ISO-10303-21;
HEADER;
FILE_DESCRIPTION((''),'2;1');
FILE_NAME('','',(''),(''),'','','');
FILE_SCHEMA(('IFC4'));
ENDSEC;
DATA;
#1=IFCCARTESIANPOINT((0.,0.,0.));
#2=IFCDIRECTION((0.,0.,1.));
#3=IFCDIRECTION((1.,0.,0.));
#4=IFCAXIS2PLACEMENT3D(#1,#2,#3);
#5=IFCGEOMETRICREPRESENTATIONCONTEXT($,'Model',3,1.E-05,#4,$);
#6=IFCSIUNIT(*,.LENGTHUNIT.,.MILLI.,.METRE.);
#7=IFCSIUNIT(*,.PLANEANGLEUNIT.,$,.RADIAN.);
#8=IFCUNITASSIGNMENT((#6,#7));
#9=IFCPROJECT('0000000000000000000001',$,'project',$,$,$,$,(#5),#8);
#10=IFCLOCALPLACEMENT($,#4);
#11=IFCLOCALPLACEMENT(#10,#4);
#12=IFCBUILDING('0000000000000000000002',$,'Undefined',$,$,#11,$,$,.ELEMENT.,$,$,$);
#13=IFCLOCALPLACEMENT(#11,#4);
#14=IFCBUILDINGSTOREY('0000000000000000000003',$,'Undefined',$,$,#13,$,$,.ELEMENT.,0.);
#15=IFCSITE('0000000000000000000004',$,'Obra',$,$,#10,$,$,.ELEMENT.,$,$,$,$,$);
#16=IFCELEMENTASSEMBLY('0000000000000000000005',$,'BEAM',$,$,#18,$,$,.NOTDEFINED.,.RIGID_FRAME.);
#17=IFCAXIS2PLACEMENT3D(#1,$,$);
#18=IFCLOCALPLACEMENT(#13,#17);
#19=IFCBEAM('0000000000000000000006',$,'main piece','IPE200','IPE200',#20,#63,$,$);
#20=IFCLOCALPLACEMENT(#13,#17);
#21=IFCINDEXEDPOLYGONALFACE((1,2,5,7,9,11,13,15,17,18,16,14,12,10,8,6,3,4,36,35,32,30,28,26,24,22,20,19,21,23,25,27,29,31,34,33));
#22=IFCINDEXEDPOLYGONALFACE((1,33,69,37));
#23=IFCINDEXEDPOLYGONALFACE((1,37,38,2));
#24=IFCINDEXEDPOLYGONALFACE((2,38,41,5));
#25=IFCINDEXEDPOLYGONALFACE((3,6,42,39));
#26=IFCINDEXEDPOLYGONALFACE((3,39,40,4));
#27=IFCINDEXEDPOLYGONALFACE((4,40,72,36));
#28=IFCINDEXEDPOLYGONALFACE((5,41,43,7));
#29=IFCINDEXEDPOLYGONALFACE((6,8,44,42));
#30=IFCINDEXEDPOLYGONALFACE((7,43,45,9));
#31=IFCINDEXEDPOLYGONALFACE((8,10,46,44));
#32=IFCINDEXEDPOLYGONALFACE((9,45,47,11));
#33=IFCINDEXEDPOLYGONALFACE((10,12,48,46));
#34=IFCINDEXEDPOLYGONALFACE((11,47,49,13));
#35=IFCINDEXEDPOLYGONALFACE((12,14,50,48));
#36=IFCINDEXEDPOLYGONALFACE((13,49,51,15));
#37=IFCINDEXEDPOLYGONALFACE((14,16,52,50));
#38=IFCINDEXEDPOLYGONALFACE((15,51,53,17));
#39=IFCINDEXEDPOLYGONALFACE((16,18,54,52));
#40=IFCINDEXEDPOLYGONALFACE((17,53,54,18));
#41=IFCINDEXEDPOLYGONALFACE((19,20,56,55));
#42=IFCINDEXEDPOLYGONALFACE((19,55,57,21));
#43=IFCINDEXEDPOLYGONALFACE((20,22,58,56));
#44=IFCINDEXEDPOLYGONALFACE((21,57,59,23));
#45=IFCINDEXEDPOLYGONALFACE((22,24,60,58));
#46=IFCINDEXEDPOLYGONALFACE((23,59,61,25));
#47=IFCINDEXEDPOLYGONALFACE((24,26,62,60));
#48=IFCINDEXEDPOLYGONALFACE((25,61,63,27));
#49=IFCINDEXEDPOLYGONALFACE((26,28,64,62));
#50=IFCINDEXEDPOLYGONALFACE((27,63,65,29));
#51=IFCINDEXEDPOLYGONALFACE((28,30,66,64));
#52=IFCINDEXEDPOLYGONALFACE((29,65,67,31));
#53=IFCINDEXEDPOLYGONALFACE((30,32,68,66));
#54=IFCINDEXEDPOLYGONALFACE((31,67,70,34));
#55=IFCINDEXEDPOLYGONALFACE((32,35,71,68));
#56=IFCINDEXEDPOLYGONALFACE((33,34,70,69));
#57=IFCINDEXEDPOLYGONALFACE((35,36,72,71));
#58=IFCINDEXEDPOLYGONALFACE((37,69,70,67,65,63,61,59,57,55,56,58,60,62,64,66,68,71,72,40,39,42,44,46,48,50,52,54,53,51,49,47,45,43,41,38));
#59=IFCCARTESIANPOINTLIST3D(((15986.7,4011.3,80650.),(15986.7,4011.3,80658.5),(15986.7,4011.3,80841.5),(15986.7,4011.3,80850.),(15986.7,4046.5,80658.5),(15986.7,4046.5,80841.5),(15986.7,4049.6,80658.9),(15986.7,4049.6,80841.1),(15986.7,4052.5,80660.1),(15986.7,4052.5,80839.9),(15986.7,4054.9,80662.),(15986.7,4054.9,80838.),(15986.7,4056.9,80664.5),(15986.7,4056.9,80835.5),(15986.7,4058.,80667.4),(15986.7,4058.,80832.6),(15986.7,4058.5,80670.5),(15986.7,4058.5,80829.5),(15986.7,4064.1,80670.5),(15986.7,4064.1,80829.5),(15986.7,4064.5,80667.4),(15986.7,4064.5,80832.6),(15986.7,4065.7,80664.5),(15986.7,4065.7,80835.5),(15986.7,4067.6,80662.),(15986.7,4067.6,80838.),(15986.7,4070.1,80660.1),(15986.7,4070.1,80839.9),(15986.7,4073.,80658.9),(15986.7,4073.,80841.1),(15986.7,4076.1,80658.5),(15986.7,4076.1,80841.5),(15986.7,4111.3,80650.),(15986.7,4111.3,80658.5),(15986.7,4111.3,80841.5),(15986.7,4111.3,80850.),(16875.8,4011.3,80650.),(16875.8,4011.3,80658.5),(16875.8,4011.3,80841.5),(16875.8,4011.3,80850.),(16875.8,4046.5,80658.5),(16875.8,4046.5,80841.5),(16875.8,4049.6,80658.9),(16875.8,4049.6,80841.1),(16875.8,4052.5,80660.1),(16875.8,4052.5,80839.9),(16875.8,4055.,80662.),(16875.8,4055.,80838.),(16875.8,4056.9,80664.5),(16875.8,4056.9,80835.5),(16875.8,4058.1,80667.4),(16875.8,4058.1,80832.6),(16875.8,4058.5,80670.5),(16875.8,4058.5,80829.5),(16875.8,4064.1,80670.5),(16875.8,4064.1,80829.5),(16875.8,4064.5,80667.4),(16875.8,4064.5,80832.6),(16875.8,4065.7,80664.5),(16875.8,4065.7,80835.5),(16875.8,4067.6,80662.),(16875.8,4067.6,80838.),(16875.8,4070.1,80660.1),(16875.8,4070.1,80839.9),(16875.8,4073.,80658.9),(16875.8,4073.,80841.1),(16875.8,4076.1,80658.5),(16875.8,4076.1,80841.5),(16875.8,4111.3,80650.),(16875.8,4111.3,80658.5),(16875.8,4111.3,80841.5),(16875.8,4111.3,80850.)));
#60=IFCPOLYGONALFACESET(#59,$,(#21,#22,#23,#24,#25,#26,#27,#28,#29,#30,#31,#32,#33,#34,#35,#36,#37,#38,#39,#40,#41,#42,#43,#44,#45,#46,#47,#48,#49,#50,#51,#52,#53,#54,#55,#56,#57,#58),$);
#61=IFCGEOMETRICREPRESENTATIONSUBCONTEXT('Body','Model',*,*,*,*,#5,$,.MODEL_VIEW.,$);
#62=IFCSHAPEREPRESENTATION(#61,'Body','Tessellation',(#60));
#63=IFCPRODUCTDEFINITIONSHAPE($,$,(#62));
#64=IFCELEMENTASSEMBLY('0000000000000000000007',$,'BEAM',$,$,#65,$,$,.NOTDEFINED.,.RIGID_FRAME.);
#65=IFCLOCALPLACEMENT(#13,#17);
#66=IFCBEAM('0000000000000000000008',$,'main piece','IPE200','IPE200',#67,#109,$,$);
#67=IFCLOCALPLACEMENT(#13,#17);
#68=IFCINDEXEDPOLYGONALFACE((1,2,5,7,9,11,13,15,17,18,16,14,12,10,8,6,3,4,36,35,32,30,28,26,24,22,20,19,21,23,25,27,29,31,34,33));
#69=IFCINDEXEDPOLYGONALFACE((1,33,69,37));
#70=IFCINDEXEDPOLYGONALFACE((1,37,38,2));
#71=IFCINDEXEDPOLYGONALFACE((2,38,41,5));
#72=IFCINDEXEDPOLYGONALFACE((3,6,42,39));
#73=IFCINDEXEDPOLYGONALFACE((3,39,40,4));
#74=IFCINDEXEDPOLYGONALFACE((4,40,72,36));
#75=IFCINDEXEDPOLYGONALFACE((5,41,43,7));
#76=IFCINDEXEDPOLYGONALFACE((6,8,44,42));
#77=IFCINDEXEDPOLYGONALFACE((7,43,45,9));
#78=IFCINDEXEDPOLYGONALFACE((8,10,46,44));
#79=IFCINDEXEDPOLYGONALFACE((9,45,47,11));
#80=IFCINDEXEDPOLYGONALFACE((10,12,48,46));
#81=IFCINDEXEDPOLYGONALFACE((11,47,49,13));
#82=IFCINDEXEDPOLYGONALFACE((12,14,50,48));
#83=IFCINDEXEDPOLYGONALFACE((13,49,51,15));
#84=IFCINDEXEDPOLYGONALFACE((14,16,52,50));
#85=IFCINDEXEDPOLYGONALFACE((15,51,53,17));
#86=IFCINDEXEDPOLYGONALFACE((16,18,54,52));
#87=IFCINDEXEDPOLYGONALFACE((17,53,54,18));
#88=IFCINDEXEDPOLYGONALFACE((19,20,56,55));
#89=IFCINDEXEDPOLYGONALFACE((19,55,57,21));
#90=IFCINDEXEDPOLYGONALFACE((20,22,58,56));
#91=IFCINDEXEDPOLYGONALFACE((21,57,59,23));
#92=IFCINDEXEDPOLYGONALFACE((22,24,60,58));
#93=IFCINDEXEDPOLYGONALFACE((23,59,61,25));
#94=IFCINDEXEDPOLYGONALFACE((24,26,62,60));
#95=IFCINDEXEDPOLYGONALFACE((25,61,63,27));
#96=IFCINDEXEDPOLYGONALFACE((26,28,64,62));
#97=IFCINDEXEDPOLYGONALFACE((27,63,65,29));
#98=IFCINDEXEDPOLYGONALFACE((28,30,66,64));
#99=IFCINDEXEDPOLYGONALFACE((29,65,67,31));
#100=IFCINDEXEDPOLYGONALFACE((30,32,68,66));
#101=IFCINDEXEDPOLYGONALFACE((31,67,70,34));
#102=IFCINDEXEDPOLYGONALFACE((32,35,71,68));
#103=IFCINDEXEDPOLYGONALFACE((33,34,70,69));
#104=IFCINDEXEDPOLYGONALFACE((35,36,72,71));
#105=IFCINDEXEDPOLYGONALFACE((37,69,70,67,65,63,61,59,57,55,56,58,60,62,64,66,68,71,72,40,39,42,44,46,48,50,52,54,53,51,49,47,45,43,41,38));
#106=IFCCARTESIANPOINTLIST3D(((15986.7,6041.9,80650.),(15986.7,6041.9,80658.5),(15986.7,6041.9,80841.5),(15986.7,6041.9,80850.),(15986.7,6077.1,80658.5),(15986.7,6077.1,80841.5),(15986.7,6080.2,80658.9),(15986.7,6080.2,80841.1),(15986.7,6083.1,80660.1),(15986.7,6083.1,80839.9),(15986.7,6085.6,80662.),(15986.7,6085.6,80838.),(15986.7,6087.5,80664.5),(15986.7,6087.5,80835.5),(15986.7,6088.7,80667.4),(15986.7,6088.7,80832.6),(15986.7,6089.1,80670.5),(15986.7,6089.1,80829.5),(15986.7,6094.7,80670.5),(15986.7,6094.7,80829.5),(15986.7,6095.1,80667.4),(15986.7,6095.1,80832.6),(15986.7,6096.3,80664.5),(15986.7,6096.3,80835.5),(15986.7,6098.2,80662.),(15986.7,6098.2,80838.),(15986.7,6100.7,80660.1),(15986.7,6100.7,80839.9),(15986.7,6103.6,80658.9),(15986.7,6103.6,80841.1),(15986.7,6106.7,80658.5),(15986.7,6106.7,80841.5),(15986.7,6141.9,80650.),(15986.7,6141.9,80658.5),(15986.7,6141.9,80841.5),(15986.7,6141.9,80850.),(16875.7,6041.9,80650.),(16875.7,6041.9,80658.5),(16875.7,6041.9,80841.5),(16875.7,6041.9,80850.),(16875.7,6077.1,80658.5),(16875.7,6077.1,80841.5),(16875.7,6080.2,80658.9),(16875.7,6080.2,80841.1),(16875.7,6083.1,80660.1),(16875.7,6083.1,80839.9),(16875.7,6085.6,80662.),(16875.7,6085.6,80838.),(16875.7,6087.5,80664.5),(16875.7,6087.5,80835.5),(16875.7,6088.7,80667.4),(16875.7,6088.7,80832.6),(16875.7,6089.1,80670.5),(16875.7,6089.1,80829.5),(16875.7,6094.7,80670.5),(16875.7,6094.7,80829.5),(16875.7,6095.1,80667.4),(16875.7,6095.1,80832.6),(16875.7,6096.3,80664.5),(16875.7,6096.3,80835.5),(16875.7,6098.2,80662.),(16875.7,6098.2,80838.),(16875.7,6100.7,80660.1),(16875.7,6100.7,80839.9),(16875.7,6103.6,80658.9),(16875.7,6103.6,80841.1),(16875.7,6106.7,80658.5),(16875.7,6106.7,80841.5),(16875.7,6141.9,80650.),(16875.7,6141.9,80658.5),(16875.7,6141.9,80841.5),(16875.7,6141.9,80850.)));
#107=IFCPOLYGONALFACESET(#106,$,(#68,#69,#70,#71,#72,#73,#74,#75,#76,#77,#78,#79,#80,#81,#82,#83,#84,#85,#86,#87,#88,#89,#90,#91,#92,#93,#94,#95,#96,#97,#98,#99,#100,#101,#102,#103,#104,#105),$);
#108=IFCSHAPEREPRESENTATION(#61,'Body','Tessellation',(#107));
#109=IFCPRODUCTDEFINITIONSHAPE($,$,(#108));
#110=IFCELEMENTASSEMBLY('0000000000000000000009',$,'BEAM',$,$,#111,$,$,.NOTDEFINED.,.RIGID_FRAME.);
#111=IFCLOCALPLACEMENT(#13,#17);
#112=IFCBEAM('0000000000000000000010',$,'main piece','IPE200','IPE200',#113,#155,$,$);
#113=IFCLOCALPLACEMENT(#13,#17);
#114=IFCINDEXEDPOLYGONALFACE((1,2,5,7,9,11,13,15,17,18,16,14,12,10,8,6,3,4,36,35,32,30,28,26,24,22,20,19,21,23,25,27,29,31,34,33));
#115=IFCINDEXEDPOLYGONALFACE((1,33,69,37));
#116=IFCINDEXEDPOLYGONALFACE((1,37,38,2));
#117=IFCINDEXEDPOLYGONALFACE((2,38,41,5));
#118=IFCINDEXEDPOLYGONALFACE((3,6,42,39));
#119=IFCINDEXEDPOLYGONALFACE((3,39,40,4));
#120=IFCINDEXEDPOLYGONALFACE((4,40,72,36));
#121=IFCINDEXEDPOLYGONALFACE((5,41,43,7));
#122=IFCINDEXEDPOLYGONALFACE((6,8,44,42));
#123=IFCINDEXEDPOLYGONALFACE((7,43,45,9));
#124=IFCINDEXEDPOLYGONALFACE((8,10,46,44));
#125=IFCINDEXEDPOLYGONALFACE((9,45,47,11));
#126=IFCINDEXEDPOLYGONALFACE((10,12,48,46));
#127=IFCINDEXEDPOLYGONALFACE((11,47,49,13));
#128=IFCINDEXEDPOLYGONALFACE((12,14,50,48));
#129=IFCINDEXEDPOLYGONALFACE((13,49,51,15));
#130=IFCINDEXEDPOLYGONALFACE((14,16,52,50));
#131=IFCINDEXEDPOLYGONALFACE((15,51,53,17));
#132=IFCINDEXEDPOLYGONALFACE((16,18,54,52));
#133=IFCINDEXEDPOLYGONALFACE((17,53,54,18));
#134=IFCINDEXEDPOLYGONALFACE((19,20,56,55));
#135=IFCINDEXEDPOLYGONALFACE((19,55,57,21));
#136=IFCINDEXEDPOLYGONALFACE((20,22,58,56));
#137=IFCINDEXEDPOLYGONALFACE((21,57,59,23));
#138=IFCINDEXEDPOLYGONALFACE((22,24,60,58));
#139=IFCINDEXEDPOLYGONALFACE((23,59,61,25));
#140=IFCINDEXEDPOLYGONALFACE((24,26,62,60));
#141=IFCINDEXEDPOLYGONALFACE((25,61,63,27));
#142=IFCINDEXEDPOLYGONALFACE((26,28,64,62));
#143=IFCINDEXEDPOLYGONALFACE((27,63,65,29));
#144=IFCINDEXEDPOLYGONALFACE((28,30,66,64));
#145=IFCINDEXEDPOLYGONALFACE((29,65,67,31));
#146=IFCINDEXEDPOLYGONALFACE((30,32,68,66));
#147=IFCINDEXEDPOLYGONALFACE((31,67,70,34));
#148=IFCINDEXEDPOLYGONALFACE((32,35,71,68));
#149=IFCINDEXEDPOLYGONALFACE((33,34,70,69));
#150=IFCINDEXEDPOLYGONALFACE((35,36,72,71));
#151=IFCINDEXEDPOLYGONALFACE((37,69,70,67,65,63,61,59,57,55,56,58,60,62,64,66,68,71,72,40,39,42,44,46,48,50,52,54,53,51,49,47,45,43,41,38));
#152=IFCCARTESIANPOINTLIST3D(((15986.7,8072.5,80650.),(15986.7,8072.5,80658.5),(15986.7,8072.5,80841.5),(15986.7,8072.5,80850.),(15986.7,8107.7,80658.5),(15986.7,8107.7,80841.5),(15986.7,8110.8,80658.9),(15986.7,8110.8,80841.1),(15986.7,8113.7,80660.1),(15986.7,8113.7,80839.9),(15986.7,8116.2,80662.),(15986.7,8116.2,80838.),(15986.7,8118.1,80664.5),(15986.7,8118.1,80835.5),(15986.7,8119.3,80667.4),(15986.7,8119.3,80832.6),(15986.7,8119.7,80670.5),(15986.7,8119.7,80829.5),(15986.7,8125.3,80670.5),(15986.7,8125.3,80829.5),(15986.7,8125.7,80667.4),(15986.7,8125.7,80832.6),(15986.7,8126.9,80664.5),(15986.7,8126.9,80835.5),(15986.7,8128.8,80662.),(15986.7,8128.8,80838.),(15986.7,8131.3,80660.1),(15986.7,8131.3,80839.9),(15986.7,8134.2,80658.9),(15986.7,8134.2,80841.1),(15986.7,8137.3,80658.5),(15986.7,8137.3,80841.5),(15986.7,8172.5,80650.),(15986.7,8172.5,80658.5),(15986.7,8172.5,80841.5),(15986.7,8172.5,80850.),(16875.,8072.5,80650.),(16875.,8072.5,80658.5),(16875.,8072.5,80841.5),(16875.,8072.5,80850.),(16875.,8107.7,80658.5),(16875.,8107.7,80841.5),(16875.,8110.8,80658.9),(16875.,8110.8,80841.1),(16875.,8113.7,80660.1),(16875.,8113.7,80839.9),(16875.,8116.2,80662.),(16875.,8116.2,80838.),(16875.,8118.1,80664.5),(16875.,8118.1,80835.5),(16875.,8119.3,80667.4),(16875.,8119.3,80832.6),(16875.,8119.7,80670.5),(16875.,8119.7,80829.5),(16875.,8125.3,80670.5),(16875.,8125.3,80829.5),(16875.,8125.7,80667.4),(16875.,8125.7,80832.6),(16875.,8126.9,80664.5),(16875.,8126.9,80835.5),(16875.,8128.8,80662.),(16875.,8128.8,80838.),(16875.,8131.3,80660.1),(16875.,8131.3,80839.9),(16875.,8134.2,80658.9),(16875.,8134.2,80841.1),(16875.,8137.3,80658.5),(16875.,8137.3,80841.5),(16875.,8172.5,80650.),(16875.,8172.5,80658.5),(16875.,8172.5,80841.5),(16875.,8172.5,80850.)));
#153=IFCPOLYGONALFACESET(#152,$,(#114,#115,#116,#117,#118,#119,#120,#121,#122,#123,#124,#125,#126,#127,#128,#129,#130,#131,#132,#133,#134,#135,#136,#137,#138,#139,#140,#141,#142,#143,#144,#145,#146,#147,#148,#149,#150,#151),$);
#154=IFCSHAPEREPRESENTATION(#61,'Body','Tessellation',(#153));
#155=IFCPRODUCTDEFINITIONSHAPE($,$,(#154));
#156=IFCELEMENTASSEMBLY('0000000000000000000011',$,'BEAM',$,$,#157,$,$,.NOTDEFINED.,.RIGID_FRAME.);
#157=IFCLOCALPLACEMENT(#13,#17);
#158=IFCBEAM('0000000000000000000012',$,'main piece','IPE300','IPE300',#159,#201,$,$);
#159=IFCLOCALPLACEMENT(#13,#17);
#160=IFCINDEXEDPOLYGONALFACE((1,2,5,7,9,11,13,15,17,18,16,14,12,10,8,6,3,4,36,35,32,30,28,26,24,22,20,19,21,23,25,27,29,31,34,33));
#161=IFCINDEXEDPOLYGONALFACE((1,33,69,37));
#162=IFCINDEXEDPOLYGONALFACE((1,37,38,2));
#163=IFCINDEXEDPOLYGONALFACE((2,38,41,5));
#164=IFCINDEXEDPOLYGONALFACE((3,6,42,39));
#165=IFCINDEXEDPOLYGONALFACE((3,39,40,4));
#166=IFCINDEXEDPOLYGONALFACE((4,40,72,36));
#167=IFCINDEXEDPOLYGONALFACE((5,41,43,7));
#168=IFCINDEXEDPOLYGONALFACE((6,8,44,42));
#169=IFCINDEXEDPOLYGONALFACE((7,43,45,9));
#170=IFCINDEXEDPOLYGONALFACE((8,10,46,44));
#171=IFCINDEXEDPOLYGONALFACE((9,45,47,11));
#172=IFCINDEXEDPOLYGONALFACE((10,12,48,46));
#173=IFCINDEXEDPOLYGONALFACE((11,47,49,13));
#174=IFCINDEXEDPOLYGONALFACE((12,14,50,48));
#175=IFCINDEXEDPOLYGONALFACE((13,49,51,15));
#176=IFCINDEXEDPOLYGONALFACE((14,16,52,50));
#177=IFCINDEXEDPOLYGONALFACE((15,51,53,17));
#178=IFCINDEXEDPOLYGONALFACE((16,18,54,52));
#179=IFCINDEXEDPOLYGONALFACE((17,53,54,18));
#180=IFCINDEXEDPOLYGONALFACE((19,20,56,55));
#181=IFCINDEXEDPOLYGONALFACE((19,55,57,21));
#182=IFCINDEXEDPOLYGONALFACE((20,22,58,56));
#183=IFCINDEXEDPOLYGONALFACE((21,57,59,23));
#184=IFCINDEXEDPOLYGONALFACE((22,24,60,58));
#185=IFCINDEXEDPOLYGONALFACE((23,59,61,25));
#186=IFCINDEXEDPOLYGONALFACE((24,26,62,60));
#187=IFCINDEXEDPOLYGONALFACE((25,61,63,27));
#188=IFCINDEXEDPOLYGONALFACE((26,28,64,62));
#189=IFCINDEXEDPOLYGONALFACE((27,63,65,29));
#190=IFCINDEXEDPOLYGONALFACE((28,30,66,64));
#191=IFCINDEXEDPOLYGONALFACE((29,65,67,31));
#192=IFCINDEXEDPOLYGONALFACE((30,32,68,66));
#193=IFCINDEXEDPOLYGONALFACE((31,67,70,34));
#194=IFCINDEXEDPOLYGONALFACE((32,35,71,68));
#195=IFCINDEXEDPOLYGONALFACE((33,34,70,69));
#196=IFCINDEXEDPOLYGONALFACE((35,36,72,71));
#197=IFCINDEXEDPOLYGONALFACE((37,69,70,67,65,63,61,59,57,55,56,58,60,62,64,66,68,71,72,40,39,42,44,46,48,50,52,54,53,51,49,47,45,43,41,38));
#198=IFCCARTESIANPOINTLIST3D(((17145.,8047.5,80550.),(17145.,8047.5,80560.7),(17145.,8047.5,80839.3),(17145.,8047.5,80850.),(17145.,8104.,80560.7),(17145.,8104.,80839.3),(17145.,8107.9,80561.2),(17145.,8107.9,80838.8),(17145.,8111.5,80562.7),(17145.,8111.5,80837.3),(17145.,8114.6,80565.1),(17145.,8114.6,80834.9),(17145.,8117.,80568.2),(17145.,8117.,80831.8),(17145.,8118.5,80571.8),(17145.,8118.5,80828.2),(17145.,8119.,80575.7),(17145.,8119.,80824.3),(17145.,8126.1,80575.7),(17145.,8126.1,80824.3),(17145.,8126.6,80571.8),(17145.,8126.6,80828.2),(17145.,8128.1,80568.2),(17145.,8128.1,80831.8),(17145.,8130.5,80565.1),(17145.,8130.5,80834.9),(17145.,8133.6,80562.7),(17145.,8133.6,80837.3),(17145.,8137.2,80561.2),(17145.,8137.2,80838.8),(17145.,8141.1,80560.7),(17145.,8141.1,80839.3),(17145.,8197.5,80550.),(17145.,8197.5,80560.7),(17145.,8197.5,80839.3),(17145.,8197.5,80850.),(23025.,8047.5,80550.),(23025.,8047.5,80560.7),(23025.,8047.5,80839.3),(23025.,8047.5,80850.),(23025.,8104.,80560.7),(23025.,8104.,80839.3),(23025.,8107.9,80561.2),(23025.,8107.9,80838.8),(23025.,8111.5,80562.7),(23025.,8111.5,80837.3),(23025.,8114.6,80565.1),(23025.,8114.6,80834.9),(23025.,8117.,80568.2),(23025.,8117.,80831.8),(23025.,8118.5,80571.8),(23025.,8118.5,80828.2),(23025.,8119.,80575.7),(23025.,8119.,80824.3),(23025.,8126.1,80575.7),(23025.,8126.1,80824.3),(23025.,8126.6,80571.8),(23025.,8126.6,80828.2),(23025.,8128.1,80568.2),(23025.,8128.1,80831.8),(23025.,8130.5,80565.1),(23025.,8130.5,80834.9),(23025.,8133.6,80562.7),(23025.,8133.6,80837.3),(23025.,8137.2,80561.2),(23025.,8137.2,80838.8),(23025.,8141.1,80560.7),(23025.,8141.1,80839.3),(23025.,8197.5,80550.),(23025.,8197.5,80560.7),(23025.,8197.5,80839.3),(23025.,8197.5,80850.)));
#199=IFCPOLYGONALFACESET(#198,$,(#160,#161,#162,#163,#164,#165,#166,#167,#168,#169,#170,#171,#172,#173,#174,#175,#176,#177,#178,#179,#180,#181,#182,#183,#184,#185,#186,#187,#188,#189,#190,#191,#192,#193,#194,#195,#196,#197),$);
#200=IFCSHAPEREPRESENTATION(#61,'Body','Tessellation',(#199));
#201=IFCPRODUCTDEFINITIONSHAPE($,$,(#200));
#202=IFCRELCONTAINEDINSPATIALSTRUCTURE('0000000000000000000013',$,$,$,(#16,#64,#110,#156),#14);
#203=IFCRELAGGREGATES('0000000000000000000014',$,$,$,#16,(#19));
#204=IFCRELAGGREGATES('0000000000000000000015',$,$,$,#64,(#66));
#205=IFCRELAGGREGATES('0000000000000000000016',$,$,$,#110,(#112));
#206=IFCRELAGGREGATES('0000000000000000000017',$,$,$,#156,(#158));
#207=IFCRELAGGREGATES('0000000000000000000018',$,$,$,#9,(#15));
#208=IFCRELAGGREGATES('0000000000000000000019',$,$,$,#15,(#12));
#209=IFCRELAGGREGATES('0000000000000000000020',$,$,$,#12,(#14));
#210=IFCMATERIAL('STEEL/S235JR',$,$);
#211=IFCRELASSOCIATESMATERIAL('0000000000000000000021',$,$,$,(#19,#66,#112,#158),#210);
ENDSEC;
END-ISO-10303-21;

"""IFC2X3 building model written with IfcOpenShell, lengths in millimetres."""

from ifc_helpers import new_model, si_unit, frame, origin_with_axes, origin_2d_with_axis, place, context, subcontext, project, spatial, i_section, extrude, material, element, aggregate, save


model = new_model("IFC2X3")

# Units and contexts
model_context = context("Model", 3, precision=1e-05, world=origin_with_axes())
body_context = subcontext(model_context, "Body", "Model", "MODEL_VIEW")
ifc_project = project(units=[si_unit("LENGTHUNIT", "METRE", prefix="MILLI"), si_unit("PLANEANGLEUNIT", "RADIAN")], contexts=[model_context])

# Site, building, storey
site_placement = place(None, origin_with_axes())
site = spatial("IfcSite", under=ifc_project, at=site_placement, Name="Obra", CompositionType="ELEMENT")
building_placement = place(site_placement, origin_with_axes())
building = spatial("IfcBuilding", under=site, at=building_placement, Name="Undefined", CompositionType="ELEMENT")
storey_placement = place(building_placement, origin_with_axes())
storey = spatial("IfcBuildingStorey", under=building, at=storey_placement, Name="Undefined", CompositionType="ELEMENT", Elevation=0.0)

# Element assemblies, beams
ifc_material = material(Name="STEEL/S235JR")
assembly_1_placement = place(storey_placement, origin_with_axes())
assembly_1 = element("IfcElementAssembly", 1, at=assembly_1_placement, inside=storey, Name="BEAM", AssemblyPlace="NOTDEFINED", PredefinedType="RIGID_FRAME")
beam_1_placement = place(assembly_1_placement, frame((16875.8, 4061.3, 80750.0), z_axis=(0.0, 0.0, 1.0), x_axis=(-1.0, -0.000044, 0.0)))
beam_1 = element("IfcBeam", 2, at=beam_1_placement, material=ifc_material, Name="main piece", Description="IPE200", ObjectType="IPE200", context=body_context, shape_type="SweptSolid", body=[
    extrude(i_section(OverallWidth=100.0, OverallDepth=200.0, WebThickness=5.6, FlangeThickness=8.5, FilletRadius=12.0, at=origin_2d_with_axis()), frame((889.1, 0.0, 0.0), z_axis=(-1.0, 0.0, 0.0), x_axis=(0.0, -1.0, 0.0)), (0.0, 0.0, 1.0), 889.1),
])
aggregate(assembly_1, [beam_1])
assembly_2_placement = place(storey_placement, origin_with_axes())
assembly_2 = element("IfcElementAssembly", 3, at=assembly_2_placement, inside=storey, Name="BEAM", AssemblyPlace="NOTDEFINED", PredefinedType="RIGID_FRAME")
beam_2_placement = place(assembly_2_placement, frame((16875.7, 6091.9, 80750.0), z_axis=(0.0, 0.0, 1.0), x_axis=(-1.0, 0.0, 0.0)))
beam_2 = element("IfcBeam", 4, at=beam_2_placement, material=ifc_material, Name="main piece", Description="IPE200", ObjectType="IPE200", context=body_context, shape_type="SweptSolid", body=[
    extrude(i_section(OverallWidth=100.0, OverallDepth=200.0, WebThickness=5.6, FlangeThickness=8.5, FilletRadius=12.0, at=origin_2d_with_axis()), frame((889.0, 0.0, 0.0), z_axis=(-1.0, 0.0, 0.0), x_axis=(0.0, -1.0, 0.0)), (0.0, 0.0, 1.0), 889.0),
])
aggregate(assembly_2, [beam_2])
assembly_3_placement = place(storey_placement, origin_with_axes())
assembly_3 = element("IfcElementAssembly", 5, at=assembly_3_placement, inside=storey, Name="BEAM", AssemblyPlace="NOTDEFINED", PredefinedType="RIGID_FRAME")
beam_3_placement = place(assembly_3_placement, frame((15986.7, 8122.5, 80750.0), z_axis=(0.0, 0.0, 1.0), x_axis=(1.0, 0.0, 0.0)))
beam_3 = element("IfcBeam", 6, at=beam_3_placement, material=ifc_material, Name="main piece", Description="IPE200", ObjectType="IPE200", context=body_context, shape_type="SweptSolid", body=[
    extrude(i_section(OverallWidth=100.0, OverallDepth=200.0, WebThickness=5.6, FlangeThickness=8.5, FilletRadius=12.0, at=origin_2d_with_axis()), frame((888.3, 0.0, 0.0), z_axis=(-1.0, 0.0, 0.0), x_axis=(0.0, -1.0, 0.0)), (0.0, 0.0, 1.0), 888.3),
])
aggregate(assembly_3, [beam_3])
assembly_4_placement = place(storey_placement, origin_with_axes())
assembly_4 = element("IfcElementAssembly", 7, at=assembly_4_placement, inside=storey, Name="BEAM", AssemblyPlace="NOTDEFINED", PredefinedType="RIGID_FRAME")
beam_4_placement = place(assembly_4_placement, frame((17145.0, 8122.5, 80700.0), z_axis=(0.0, 0.0, 1.0), x_axis=(1.0, 0.0, 0.0)))
beam_4 = element("IfcBeam", 8, at=beam_4_placement, material=ifc_material, Name="main piece", Description="IPE300", ObjectType="IPE300", context=body_context, shape_type="SweptSolid", body=[
    extrude(i_section(OverallWidth=150.0, OverallDepth=300.0, WebThickness=7.1, FlangeThickness=10.7, FilletRadius=15.0, at=origin_2d_with_axis()), frame((5880.0, 0.0, 0.0), z_axis=(-1.0, 0.0, 0.0), x_axis=(0.0, -1.0, 0.0)), (0.0, 0.0, 1.0), 5880.0),
])
aggregate(assembly_4, [beam_4])

save(model, "model.ifc")
